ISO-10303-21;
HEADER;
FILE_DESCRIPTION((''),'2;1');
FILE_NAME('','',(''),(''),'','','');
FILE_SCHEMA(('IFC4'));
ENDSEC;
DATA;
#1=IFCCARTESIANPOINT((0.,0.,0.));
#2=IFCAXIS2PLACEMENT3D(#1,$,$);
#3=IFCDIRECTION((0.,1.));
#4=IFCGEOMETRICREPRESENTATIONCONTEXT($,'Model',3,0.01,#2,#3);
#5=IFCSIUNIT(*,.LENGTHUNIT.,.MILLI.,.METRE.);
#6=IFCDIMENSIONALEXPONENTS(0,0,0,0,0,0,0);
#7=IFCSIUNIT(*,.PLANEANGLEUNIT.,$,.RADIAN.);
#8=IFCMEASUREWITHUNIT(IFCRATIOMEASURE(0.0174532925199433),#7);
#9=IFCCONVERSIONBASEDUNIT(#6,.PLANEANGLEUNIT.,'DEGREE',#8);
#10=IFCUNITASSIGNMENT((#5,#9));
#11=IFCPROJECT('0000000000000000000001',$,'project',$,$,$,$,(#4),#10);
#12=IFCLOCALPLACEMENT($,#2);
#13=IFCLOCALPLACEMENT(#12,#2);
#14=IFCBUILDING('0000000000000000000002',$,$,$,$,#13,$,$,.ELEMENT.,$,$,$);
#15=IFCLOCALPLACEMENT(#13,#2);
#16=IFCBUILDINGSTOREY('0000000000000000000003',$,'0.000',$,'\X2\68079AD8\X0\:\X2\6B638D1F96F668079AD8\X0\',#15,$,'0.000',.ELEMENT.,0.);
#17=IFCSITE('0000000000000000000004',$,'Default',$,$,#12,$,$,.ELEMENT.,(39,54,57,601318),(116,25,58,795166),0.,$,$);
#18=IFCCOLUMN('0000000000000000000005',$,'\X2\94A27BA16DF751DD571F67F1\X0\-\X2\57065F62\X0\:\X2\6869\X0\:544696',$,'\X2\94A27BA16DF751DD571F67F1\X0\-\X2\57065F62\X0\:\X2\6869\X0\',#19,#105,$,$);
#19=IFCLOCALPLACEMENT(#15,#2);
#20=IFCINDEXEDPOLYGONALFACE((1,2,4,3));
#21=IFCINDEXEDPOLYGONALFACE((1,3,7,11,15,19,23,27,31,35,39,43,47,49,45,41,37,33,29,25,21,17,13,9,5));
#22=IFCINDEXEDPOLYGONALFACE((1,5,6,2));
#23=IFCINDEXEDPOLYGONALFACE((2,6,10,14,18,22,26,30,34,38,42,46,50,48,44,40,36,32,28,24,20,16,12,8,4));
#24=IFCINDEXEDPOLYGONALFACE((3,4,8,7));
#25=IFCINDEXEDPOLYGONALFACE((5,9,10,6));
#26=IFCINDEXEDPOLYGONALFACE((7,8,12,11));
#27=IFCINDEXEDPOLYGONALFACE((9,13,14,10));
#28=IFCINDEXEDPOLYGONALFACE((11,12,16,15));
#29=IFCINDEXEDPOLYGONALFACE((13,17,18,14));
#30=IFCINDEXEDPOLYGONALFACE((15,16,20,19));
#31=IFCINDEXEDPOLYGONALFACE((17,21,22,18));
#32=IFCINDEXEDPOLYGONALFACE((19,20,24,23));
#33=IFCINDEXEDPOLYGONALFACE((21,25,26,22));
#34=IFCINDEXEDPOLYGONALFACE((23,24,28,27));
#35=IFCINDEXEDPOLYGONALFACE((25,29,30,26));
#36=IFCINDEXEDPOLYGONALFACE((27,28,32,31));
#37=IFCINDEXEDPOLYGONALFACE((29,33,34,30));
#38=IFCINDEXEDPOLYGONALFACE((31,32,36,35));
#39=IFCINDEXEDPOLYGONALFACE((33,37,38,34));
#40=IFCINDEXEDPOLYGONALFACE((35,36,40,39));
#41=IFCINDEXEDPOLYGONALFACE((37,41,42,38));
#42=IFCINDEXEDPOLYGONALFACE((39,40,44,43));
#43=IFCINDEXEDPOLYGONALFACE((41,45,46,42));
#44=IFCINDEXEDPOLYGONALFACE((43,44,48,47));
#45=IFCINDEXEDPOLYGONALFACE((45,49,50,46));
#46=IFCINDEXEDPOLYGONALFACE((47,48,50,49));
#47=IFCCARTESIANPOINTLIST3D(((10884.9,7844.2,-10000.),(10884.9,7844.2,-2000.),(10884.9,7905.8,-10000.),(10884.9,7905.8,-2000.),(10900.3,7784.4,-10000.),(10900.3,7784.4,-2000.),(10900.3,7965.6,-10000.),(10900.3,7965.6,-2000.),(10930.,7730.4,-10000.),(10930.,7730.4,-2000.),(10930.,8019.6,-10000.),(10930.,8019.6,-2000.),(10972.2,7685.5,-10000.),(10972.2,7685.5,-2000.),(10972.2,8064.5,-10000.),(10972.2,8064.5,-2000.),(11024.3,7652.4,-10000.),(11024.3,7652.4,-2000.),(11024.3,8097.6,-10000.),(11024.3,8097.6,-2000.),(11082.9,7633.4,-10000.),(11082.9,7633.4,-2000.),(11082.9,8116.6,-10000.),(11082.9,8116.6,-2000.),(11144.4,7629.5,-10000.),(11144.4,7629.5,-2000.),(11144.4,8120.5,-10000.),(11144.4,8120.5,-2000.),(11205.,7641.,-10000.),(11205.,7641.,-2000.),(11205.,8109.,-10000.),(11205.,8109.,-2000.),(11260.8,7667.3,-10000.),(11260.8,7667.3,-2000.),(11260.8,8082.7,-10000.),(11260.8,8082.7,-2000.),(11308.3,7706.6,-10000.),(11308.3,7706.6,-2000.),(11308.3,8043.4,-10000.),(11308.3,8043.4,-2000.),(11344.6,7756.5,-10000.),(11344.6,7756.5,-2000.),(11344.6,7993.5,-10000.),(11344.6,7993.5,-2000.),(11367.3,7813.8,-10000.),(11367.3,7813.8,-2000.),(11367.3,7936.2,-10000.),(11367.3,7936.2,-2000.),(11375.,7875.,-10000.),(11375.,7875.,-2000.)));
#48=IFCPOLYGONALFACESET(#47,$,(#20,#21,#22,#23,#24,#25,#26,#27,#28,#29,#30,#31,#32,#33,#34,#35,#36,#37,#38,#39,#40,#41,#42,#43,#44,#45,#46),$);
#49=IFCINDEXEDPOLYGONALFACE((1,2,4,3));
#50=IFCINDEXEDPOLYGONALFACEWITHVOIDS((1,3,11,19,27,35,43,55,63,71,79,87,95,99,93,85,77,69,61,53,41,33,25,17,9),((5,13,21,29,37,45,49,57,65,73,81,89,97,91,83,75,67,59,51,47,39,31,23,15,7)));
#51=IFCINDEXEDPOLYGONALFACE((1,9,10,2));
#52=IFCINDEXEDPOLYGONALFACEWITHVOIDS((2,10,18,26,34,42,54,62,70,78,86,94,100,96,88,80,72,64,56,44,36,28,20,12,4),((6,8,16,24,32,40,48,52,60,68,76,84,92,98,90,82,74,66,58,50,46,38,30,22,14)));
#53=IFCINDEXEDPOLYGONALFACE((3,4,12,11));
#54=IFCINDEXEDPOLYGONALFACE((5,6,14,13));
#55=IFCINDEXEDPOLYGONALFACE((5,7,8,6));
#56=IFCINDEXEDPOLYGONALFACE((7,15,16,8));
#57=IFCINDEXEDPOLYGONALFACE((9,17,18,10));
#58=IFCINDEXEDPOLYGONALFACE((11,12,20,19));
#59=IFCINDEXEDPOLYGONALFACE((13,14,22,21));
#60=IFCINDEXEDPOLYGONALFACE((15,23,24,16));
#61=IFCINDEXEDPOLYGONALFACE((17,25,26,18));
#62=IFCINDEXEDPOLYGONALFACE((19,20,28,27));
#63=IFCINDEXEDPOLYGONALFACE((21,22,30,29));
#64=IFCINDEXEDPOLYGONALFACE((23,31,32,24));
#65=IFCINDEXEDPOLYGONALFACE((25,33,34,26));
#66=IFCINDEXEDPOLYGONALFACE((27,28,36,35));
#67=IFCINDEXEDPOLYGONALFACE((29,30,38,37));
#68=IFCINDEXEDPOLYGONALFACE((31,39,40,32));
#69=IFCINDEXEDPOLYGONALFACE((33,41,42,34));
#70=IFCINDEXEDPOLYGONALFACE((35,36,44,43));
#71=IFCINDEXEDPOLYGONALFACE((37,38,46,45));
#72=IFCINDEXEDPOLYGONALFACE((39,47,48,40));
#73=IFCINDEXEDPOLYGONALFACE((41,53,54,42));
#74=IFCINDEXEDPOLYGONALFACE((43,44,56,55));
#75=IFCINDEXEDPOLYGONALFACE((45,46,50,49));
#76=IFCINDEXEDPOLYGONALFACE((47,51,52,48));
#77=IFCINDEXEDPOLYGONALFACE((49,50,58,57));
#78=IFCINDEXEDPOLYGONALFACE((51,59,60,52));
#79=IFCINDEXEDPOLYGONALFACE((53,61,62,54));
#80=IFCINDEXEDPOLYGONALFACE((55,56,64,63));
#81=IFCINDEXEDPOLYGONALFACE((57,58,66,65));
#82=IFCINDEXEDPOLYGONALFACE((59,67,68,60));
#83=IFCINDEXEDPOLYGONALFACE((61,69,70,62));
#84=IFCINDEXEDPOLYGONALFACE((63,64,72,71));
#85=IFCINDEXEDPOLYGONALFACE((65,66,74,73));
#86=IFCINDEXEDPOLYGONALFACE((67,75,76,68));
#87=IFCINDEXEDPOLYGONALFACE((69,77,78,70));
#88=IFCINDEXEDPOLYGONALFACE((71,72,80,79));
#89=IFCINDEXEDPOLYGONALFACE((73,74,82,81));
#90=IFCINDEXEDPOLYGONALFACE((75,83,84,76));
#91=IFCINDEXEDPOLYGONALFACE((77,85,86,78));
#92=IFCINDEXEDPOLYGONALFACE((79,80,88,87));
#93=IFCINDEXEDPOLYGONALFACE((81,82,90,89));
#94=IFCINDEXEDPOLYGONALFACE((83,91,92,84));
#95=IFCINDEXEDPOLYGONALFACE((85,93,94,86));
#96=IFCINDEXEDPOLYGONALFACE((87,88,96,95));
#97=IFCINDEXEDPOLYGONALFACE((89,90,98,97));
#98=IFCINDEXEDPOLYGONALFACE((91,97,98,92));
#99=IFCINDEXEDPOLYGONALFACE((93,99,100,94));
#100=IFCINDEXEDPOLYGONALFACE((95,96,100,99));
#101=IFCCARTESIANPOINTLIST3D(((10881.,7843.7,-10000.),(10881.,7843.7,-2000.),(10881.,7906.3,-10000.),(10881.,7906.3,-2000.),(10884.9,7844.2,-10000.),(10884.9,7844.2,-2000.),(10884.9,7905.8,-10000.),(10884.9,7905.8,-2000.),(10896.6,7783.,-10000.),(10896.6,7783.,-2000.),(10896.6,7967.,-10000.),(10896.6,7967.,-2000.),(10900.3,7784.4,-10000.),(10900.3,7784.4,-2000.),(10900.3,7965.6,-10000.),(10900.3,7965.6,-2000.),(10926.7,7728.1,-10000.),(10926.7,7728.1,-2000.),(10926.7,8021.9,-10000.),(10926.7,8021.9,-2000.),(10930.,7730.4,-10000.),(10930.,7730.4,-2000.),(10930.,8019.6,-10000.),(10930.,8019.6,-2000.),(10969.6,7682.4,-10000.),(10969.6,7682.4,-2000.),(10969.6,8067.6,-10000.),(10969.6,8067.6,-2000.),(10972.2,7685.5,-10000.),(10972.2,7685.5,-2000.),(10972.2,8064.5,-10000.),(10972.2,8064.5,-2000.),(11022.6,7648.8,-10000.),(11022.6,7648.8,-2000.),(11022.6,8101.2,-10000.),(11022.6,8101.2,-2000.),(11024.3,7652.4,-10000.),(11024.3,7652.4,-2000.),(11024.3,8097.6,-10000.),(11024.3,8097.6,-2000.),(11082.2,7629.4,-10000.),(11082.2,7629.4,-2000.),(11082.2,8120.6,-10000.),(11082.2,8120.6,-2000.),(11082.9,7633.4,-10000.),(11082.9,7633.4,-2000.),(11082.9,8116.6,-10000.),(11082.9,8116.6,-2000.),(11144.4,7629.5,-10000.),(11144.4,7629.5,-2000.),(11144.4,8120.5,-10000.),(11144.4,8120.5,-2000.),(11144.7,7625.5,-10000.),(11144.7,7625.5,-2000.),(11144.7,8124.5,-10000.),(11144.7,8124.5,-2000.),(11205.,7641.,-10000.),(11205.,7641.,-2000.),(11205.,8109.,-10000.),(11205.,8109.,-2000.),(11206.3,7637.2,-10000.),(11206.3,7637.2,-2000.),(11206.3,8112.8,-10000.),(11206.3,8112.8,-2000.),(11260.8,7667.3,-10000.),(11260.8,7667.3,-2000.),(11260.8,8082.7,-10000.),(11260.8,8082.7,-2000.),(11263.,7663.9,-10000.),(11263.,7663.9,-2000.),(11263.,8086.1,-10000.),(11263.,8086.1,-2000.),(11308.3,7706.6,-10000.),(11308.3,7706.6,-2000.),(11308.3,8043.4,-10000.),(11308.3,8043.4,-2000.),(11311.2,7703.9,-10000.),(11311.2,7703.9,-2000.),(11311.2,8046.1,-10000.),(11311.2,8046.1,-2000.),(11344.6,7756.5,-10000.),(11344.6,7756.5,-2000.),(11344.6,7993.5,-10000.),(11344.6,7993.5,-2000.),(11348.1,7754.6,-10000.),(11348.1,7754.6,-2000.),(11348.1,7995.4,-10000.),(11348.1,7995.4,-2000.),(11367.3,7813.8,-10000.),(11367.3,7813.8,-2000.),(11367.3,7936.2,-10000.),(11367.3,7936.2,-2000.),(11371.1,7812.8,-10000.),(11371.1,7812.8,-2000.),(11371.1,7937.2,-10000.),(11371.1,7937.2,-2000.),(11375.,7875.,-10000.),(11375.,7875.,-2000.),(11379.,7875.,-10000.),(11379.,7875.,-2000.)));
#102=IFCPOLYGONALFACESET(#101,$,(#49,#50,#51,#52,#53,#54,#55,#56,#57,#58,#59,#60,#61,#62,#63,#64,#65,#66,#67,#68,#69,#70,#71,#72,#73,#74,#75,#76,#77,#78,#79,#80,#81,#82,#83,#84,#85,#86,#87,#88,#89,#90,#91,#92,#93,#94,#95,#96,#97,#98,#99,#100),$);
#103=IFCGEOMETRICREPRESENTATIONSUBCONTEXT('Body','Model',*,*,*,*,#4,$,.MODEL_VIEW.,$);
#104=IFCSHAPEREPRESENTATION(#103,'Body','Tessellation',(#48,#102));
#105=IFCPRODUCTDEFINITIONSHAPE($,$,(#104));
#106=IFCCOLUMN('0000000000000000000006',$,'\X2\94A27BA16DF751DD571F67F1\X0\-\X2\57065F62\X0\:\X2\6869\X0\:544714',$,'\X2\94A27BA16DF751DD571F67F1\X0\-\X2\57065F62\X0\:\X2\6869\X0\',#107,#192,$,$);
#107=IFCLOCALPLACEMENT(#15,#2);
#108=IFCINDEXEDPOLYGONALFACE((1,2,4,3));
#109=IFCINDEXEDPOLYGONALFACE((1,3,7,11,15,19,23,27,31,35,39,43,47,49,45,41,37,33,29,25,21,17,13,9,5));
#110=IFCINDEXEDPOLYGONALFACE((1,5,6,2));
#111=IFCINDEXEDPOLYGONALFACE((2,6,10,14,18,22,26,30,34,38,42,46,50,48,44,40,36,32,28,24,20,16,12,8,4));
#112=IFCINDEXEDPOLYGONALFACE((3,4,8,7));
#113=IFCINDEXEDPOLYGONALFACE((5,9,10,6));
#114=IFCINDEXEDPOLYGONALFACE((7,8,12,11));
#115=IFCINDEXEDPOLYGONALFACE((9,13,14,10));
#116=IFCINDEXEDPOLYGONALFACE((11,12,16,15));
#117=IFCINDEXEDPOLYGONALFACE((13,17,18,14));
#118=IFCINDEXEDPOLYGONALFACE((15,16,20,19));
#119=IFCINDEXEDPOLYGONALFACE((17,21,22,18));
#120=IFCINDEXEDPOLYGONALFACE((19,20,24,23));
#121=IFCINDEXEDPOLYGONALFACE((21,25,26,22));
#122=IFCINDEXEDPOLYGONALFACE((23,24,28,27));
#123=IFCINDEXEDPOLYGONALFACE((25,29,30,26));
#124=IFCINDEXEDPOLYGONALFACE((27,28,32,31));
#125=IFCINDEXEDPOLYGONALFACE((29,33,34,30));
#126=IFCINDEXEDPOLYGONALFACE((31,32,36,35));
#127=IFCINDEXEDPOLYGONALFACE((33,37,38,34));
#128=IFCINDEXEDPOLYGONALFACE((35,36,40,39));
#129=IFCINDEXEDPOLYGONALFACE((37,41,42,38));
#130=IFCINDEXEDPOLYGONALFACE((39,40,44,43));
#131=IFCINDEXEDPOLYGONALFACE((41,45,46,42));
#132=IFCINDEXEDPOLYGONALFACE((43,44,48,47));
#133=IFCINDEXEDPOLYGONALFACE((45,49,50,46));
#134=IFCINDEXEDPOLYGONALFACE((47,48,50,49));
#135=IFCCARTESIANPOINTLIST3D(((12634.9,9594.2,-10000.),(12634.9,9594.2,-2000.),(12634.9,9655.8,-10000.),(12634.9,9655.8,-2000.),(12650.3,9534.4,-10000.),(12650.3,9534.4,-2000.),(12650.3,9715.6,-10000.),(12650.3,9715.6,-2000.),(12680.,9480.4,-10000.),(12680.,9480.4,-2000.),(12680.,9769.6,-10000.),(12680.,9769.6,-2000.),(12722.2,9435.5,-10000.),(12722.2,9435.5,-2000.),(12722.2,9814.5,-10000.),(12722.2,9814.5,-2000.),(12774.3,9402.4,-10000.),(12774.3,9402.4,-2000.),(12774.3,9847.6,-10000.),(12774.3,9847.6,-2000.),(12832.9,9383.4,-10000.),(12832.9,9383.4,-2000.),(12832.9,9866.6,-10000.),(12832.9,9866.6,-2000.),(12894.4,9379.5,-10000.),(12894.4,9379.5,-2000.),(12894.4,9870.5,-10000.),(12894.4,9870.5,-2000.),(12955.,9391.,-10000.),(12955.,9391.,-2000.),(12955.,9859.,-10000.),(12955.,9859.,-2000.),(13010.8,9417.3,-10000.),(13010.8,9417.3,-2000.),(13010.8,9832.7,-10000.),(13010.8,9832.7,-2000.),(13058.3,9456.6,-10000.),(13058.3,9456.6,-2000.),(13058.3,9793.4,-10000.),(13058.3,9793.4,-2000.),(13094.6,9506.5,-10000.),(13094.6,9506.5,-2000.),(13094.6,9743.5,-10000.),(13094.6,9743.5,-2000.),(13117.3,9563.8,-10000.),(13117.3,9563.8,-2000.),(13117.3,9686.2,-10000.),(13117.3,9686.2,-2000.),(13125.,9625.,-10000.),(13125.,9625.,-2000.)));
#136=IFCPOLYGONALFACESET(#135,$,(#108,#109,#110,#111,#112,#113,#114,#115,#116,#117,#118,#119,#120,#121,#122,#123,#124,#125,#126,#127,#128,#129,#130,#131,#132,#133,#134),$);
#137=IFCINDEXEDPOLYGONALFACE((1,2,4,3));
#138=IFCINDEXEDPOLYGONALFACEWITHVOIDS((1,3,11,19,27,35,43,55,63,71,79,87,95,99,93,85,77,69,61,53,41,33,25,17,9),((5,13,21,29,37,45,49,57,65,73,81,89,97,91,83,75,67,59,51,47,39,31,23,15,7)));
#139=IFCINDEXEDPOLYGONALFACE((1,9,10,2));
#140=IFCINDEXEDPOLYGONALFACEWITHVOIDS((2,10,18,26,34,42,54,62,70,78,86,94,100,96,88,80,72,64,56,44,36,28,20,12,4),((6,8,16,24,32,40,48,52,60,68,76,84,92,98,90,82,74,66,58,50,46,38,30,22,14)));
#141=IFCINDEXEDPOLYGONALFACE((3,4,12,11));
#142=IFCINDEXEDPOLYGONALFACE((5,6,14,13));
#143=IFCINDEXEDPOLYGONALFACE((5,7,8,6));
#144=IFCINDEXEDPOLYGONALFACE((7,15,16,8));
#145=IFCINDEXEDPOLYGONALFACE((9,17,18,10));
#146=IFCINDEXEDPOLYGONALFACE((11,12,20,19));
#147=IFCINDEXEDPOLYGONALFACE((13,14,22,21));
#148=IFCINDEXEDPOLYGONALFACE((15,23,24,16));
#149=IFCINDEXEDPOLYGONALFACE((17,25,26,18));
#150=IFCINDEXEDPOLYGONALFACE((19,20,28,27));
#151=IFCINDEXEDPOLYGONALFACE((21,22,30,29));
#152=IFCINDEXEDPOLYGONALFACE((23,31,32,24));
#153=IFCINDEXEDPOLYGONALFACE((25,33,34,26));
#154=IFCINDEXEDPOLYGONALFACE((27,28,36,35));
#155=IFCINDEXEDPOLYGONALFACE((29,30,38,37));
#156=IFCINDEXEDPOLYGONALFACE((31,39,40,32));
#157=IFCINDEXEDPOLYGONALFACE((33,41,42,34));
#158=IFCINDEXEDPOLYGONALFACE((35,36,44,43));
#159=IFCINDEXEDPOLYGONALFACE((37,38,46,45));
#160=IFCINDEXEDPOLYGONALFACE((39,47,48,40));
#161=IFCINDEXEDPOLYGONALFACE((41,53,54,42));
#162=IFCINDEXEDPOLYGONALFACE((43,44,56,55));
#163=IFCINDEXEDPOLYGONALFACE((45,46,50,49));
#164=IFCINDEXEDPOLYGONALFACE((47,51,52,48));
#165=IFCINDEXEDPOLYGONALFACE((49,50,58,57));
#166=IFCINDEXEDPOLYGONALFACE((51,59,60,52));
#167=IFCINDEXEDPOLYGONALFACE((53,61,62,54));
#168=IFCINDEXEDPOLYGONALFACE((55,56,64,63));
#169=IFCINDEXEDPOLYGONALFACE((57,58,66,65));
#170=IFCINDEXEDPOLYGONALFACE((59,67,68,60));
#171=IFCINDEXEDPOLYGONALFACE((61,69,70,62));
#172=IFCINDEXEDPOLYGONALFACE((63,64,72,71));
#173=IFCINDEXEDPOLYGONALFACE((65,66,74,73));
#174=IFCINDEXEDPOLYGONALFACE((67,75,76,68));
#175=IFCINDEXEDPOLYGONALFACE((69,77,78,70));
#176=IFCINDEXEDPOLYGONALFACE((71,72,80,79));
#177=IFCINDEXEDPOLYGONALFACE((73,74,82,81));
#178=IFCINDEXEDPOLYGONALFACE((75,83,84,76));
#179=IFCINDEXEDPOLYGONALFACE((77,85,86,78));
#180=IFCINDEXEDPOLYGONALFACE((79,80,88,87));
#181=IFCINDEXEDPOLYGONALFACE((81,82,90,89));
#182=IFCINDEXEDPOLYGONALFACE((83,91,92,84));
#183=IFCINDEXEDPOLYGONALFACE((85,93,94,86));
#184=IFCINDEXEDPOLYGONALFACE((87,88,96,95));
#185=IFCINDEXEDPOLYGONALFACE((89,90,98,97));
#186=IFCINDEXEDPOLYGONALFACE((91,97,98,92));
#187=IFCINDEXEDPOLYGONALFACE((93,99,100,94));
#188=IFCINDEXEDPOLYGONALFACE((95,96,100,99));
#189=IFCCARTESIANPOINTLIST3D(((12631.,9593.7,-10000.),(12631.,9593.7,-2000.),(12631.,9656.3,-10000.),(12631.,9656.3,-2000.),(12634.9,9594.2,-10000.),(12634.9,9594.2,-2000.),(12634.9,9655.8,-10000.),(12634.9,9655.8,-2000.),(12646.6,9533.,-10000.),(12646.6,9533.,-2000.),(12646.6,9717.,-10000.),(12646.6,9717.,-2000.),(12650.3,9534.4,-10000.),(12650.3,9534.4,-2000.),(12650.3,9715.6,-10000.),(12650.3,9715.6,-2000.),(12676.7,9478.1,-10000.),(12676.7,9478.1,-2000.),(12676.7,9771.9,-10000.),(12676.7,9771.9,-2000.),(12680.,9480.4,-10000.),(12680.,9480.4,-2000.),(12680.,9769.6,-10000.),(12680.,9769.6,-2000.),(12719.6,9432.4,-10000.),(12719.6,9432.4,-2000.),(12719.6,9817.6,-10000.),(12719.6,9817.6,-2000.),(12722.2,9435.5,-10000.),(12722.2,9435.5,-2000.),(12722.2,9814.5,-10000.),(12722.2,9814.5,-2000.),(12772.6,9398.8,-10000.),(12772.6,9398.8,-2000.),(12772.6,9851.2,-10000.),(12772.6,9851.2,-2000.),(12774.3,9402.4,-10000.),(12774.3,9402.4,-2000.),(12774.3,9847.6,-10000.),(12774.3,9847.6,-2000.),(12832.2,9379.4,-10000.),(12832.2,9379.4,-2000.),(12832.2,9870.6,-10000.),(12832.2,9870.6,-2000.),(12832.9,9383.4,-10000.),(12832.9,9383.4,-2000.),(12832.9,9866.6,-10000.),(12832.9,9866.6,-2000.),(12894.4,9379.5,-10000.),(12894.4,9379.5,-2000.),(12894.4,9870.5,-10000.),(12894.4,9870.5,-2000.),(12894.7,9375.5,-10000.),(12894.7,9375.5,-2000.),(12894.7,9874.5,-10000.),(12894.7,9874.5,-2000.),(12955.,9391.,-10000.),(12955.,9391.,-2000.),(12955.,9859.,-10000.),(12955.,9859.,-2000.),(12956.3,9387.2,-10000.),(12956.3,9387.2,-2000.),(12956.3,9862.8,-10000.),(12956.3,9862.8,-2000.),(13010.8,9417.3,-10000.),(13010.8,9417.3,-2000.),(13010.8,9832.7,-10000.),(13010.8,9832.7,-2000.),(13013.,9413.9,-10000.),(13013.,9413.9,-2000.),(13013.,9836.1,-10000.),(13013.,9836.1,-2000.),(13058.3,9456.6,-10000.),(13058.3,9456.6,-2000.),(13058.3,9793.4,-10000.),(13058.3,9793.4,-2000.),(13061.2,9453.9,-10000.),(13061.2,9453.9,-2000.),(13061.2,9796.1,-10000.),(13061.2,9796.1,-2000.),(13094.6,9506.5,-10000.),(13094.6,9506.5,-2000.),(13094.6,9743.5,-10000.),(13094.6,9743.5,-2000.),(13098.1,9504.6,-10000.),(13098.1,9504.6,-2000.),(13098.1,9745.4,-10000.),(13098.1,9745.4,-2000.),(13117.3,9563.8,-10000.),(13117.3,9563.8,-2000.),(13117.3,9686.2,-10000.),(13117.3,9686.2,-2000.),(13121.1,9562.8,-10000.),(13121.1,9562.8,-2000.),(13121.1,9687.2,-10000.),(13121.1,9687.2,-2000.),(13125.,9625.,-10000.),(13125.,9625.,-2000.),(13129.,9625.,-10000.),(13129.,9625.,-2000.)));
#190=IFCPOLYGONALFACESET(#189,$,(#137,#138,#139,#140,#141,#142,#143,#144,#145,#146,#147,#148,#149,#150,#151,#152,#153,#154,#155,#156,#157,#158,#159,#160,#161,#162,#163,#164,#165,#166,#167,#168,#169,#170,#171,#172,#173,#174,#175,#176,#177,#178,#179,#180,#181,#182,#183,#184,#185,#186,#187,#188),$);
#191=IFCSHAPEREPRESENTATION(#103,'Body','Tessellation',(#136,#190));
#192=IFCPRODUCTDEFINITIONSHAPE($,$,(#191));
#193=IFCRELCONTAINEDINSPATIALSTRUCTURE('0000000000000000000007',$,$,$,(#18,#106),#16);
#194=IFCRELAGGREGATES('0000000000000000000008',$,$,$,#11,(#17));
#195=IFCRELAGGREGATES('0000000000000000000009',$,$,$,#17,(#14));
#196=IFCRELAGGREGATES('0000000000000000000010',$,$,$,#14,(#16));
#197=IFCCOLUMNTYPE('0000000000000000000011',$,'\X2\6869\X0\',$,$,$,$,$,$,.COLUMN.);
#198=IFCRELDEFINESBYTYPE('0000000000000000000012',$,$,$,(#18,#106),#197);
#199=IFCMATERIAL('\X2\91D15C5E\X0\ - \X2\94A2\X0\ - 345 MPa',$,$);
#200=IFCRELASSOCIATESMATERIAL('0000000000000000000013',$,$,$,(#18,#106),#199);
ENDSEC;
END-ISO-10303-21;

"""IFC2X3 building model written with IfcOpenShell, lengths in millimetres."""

from ifc_helpers import new_model, entity, si_unit, converted_unit, direction, frame, frame_2d, origin, place, context, subcontext, project, spatial, circle, hollow_circle, extrude, source, transform, mapped, material, type_object, type_shapes, element, save


model = new_model("IFC2X3")

# Units and contexts
model_context = context("Model", 3, precision=0.01, world=origin(), true_north=direction((0.0, 1.0)))
body_context = subcontext(model_context, "Body", "Model", "MODEL_VIEW")
ifc_project = project(units=[si_unit("LENGTHUNIT", "METRE", prefix="MILLI"), converted_unit("PLANEANGLEUNIT", "DEGREE", entity("IfcRatioMeasure", 0.0174532925199433), si_unit("PLANEANGLEUNIT", "RADIAN"), dimensions=[0, 0, 0, 0, 0, 0, 0])], contexts=[model_context])

# Site, building, storey
site_placement = place(None, origin())
site = spatial("IfcSite", under=ifc_project, at=site_placement, Name="Default", CompositionType="ELEMENT", RefLatitude=(39, 54, 57, 601318), RefLongitude=(116, 25, 58, 795166), RefElevation=0.0)
building_placement = place(site_placement, origin())
building = spatial("IfcBuilding", under=site, at=building_placement, CompositionType="ELEMENT")
storey_placement = place(building_placement, origin())
storey = spatial("IfcBuildingStorey", under=building, at=storey_placement, Name="0.000", ObjectType="标高:正负零标高", LongName="0.000", CompositionType="ELEMENT", Elevation=0.0)

# Columns
ifc_material_1 = material(Name="金属 - 钢 - 345 MPa")
column_type = type_object("IfcColumnType", Name="桩", PredefinedType="COLUMN")
shared_shape = source(origin(), body_context, "Body", "SweptSolid", [
    extrude(circle(Radius=246.0, at=frame_2d((0.0, 0.0), x_axis=(1.0, 0.0))), frame((0.0, 0.0, -10000.0)), (0.0, 0.0, 1.0), 8000.0),
    extrude(hollow_circle(Radius=250.0, WallThickness=4.0, at=frame_2d((0.0, 0.0), x_axis=(1.0, 0.0))), frame((0.0, 0.0, -10000.0)), (0.0, 0.0, 1.0), 8000.0),
])
type_shapes(column_type, [shared_shape])
for number, where, name in (
    (1, (11129.0, 7875.0, 0.0), "钢管混凝土柱-圆形:桩:544696"),
    (2, (12879.0, 9625.0, 0.0), "钢管混凝土柱-圆形:桩:544714"),
):
    element("IfcColumn", number, at=place(storey_placement, frame(where)), inside=storey, type_object=column_type, material=ifc_material_1, Name=name, ObjectType="钢管混凝土柱-圆形:桩", context=body_context, shape_type="MappedRepresentation", body=[
        mapped(shared_shape, transform((0.0, 0.0, 0.0), scale=1.0)),
    ])

save(model, "model.ifc")
